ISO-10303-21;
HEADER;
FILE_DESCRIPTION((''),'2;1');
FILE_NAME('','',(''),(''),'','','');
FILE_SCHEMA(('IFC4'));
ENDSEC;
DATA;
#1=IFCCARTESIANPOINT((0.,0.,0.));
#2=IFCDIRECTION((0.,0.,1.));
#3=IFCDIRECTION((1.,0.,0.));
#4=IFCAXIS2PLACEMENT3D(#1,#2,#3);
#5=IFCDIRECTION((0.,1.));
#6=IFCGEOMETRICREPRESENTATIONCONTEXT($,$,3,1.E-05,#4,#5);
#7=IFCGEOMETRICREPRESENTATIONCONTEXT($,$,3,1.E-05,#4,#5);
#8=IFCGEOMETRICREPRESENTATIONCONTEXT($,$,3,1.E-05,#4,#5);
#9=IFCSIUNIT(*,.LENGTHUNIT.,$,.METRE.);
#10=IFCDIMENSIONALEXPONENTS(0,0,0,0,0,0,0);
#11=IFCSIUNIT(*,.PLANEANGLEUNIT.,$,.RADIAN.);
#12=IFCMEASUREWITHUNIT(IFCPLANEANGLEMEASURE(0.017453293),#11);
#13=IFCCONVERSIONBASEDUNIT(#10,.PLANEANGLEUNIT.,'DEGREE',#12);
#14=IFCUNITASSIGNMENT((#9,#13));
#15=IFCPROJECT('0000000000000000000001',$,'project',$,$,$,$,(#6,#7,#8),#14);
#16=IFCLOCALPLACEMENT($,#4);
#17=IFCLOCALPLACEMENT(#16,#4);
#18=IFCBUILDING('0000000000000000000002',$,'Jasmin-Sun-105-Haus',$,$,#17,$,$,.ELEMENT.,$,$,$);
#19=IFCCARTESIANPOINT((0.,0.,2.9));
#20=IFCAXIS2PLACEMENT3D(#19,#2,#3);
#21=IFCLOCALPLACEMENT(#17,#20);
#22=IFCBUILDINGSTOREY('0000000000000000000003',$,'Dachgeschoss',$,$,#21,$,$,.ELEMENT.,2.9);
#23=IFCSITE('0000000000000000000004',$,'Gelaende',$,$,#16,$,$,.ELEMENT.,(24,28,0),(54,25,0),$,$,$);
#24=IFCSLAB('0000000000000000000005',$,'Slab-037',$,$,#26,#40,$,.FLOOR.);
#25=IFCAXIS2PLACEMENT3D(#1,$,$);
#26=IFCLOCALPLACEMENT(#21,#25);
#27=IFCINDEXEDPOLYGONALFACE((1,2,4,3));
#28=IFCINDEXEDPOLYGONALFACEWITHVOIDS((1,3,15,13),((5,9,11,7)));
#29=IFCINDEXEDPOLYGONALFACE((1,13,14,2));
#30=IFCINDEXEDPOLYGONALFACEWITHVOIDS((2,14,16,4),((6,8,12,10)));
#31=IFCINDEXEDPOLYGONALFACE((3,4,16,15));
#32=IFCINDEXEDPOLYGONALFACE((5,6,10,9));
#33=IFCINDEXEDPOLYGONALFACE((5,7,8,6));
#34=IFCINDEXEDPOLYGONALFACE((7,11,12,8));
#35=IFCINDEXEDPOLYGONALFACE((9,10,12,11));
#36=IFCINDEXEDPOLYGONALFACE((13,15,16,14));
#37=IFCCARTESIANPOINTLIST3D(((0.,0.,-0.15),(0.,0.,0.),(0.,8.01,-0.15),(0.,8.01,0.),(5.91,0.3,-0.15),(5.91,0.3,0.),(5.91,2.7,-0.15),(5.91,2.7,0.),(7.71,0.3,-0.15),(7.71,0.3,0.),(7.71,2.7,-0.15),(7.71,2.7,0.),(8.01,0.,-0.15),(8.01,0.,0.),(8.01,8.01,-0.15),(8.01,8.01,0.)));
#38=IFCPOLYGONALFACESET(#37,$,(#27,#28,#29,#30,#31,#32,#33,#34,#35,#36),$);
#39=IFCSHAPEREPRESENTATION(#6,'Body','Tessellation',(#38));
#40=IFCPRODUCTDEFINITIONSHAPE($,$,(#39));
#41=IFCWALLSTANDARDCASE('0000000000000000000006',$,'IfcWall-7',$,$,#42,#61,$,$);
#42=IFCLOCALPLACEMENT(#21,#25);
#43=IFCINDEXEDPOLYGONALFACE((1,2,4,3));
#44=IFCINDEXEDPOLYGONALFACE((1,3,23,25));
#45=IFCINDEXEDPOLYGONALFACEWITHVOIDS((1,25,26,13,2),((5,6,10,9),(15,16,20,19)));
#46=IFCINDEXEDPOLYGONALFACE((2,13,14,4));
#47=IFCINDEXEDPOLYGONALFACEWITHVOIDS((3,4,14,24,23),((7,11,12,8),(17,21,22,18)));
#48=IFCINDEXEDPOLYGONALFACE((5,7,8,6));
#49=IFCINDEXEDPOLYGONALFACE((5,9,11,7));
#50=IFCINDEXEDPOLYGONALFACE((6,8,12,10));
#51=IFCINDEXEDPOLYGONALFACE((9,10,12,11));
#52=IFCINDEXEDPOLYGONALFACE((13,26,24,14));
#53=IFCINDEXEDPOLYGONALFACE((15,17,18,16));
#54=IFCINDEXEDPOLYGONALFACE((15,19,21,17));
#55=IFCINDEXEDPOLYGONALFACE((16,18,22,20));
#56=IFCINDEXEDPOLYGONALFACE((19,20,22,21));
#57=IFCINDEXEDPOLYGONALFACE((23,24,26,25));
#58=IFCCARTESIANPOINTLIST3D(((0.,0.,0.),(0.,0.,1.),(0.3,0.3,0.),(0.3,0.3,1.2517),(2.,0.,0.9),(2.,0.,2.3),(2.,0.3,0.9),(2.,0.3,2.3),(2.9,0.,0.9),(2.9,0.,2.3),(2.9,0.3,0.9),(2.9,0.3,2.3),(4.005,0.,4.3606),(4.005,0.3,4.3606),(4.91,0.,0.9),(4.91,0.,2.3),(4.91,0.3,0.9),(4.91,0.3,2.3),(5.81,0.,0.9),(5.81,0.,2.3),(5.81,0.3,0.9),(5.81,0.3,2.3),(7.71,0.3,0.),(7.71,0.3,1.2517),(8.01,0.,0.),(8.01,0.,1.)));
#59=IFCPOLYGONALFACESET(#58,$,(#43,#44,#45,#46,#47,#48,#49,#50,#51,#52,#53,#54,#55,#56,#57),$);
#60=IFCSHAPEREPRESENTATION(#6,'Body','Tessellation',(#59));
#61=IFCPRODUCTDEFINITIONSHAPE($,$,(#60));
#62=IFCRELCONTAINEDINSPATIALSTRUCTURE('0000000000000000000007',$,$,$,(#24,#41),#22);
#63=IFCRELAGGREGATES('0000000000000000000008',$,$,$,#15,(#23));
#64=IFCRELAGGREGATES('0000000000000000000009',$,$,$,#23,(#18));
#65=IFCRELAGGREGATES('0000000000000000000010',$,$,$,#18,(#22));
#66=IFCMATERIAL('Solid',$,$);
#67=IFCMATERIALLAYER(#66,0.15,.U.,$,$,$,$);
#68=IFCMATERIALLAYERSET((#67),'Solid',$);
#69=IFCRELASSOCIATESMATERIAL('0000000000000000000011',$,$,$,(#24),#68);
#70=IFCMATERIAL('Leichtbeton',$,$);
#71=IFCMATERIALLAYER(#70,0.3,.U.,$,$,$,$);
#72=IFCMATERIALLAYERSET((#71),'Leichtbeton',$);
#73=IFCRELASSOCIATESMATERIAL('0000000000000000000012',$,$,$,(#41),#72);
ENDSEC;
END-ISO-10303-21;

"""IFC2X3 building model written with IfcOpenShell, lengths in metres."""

from ifc_helpers import new_model, entity, si_unit, converted_unit, direction, frame, frame_2d, origin_with_axes, place, context, project, spatial, polyline, rectangle, outline, extrude, clip, bounded_halfspace, material, layer, layer_set, layer_usage, element, save


model = new_model("IFC2X3")

# Units and contexts
context_of_model_1 = context(None, 3, precision=1e-05, world=origin_with_axes(), true_north=direction((0.0, 1.0)))
context_of_model_2 = context(None, 3, precision=1e-05, world=origin_with_axes(), true_north=direction((0.0, 1.0)))
context_of_model_3 = context(None, 3, precision=1e-05, world=origin_with_axes(), true_north=direction((0.0, 1.0)))
ifc_project = project(units=[si_unit("LENGTHUNIT", "METRE"), converted_unit("PLANEANGLEUNIT", "DEGREE", entity("IfcPlaneAngleMeasure", 0.017453293), si_unit("PLANEANGLEUNIT", "RADIAN"), dimensions=[0, 0, 0, 0, 0, 0, 0])], contexts=[context_of_model_1, context_of_model_2, context_of_model_3])

# Site, building, storey
site_placement = place(None, origin_with_axes())
site = spatial("IfcSite", under=ifc_project, at=site_placement, Name="Gelaende", CompositionType="ELEMENT", RefLatitude=(24, 28, 0), RefLongitude=(54, 25, 0))
building_placement = place(site_placement, origin_with_axes())
building = spatial("IfcBuilding", under=site, at=building_placement, Name="Jasmin-Sun-105-Haus", CompositionType="ELEMENT")
storey_placement = place(building_placement, frame((0.0, 0.0, 2.9), z_axis=(0.0, 0.0, 1.0), x_axis=(1.0, 0.0, 0.0)))
storey = spatial("IfcBuildingStorey", under=building, at=storey_placement, Name="Dachgeschoss", CompositionType="ELEMENT", Elevation=2.9)

# Slab, opening
ifc_material_1 = material(Name="Solid")
ifc_layer_1 = layer(ifc_material_1, 0.15, ventilated="UNKNOWN")
ifc_layer_set_1 = layer_set([ifc_layer_1], Name="Solid")
ifc_layer_usage_1 = layer_usage(ifc_layer_set_1, "AXIS3", "NEGATIVE", 0.15)
slab_1_placement = place(storey_placement, frame((0.0, 8.01, -0.15), z_axis=(0.0, 0.0, 1.0), x_axis=(1.0, 0.0, 0.0)))
slab_1 = element("IfcSlab", 1, at=slab_1_placement, inside=storey, material=ifc_layer_usage_1, Name="Slab-037", PredefinedType="FLOOR", context=context_of_model_1, shape_type="SweptSolid", body=[
    extrude(outline(polyline([(0.0, 0.0), (8.01, 0.0), (8.01, -8.01), (0.0, -8.01), (0.0, 0.0)])), origin_with_axes(), (0.0, 0.0, 1.0), 0.15),
])
opening_1_placement = place(slab_1_placement, origin_with_axes())
element("IfcOpeningElement", 2, at=opening_1_placement, cuts=slab_1, context=context_of_model_1, shape_type="SweptSolid", body=[
    extrude(outline(polyline([(5.91, -7.71), (5.91, -5.31), (7.71, -5.31), (7.71, -7.71), (5.91, -7.71)])), origin_with_axes(), (0.0, 0.0, 1.0), 0.15),
])

# Shared definitions
ifc_material_2 = material(Name="Leichtbeton")

# Wall, openings
ifc_layer_2 = layer(ifc_material_2, 0.3, ventilated="UNKNOWN")
ifc_layer_set_2 = layer_set([ifc_layer_2], Name="Leichtbeton")
ifc_layer_usage_2 = layer_usage(ifc_layer_set_2, "AXIS2", "POSITIVE", 0.0)
wall_1_placement = place(storey_placement, origin_with_axes())
wall_1 = element("IfcWallStandardCase", 3, at=wall_1_placement, inside=storey, material=ifc_layer_usage_2, Name="IfcWall-7", context=context_of_model_1, shape_type="Clipping", body=[
    clip(clip(clip(clip(extrude(outline(polyline([(0.0, 0.0), (8.01, 0.0), (7.71, 0.3), (0.3, 0.3), (0.0, 0.0)])), origin_with_axes(), (0.0, 0.0, 1.0), 5.0), bounded_halfspace(frame((-0.4924, 0.0, 0.5868), z_axis=(-0.642788, 0.0, 0.766044), x_axis=(0.0, 1.0, 0.0)), False, origin_with_axes(), polyline([(4.005, -0.15), (4.005, 0.45), (-0.01, 0.45), (-0.01, -0.15), (4.005, -0.15)]))), bounded_halfspace(frame((-0.4924, 0.0, 0.5868), z_axis=(-0.642788, 0.0, 0.766044), x_axis=(0.0, 1.0, 0.0)), False, origin_with_axes(), polyline([(4.005, -0.15), (4.005, 0.45), (-0.01, 0.45), (-0.01, -0.15), (4.005, -0.15)]))), bounded_halfspace(frame((3.8019, 0.0, 4.531), z_axis=(0.642788, 0.0, 0.766044), x_axis=(0.0, 1.0, 0.0)), False, origin_with_axes(), polyline([(4.005, -0.15), (4.005, 0.45), (8.02, 0.45), (8.02, -0.15), (4.005, -0.15)]))), bounded_halfspace(frame((3.8019, 0.0, 4.531), z_axis=(0.642788, 0.0, 0.766044), x_axis=(0.0, 1.0, 0.0)), False, origin_with_axes(), polyline([(4.005, -0.15), (4.005, 0.45), (8.02, 0.45), (8.02, -0.15), (4.005, -0.15)]))),
])
opening_2_placement = place(wall_1_placement, frame((2.45, 0.0, 0.9), z_axis=(0.0, 0.0, 1.0), x_axis=(1.0, 0.0, 0.0)))
element("IfcOpeningElement", 4, at=opening_2_placement, cuts=wall_1, context=context_of_model_1, shape_type="SweptSolid", body=[
    extrude(rectangle(XDim=1.4, YDim=0.9, at=frame_2d((0.0, 0.7), x_axis=(0.0, 1.0))), frame((0.0, 0.0, 0.0), z_axis=(0.0, 1.0, 0.0), x_axis=(-1.0, 0.0, 0.0)), (0.0, 0.0, 1.0), 0.3),
])
opening_3_placement = place(wall_1_placement, frame((5.36, 0.0, 0.9), z_axis=(0.0, 0.0, 1.0), x_axis=(1.0, 0.0, 0.0)))
element("IfcOpeningElement", 5, at=opening_3_placement, cuts=wall_1, context=context_of_model_1, shape_type="SweptSolid", body=[
    extrude(rectangle(XDim=1.4, YDim=0.9, at=frame_2d((0.0, 0.7), x_axis=(0.0, 1.0))), frame((0.0, 0.0, 0.0), z_axis=(0.0, 1.0, 0.0), x_axis=(-1.0, 0.0, 0.0)), (0.0, 0.0, 1.0), 0.3),
])

save(model, "model.ifc")
